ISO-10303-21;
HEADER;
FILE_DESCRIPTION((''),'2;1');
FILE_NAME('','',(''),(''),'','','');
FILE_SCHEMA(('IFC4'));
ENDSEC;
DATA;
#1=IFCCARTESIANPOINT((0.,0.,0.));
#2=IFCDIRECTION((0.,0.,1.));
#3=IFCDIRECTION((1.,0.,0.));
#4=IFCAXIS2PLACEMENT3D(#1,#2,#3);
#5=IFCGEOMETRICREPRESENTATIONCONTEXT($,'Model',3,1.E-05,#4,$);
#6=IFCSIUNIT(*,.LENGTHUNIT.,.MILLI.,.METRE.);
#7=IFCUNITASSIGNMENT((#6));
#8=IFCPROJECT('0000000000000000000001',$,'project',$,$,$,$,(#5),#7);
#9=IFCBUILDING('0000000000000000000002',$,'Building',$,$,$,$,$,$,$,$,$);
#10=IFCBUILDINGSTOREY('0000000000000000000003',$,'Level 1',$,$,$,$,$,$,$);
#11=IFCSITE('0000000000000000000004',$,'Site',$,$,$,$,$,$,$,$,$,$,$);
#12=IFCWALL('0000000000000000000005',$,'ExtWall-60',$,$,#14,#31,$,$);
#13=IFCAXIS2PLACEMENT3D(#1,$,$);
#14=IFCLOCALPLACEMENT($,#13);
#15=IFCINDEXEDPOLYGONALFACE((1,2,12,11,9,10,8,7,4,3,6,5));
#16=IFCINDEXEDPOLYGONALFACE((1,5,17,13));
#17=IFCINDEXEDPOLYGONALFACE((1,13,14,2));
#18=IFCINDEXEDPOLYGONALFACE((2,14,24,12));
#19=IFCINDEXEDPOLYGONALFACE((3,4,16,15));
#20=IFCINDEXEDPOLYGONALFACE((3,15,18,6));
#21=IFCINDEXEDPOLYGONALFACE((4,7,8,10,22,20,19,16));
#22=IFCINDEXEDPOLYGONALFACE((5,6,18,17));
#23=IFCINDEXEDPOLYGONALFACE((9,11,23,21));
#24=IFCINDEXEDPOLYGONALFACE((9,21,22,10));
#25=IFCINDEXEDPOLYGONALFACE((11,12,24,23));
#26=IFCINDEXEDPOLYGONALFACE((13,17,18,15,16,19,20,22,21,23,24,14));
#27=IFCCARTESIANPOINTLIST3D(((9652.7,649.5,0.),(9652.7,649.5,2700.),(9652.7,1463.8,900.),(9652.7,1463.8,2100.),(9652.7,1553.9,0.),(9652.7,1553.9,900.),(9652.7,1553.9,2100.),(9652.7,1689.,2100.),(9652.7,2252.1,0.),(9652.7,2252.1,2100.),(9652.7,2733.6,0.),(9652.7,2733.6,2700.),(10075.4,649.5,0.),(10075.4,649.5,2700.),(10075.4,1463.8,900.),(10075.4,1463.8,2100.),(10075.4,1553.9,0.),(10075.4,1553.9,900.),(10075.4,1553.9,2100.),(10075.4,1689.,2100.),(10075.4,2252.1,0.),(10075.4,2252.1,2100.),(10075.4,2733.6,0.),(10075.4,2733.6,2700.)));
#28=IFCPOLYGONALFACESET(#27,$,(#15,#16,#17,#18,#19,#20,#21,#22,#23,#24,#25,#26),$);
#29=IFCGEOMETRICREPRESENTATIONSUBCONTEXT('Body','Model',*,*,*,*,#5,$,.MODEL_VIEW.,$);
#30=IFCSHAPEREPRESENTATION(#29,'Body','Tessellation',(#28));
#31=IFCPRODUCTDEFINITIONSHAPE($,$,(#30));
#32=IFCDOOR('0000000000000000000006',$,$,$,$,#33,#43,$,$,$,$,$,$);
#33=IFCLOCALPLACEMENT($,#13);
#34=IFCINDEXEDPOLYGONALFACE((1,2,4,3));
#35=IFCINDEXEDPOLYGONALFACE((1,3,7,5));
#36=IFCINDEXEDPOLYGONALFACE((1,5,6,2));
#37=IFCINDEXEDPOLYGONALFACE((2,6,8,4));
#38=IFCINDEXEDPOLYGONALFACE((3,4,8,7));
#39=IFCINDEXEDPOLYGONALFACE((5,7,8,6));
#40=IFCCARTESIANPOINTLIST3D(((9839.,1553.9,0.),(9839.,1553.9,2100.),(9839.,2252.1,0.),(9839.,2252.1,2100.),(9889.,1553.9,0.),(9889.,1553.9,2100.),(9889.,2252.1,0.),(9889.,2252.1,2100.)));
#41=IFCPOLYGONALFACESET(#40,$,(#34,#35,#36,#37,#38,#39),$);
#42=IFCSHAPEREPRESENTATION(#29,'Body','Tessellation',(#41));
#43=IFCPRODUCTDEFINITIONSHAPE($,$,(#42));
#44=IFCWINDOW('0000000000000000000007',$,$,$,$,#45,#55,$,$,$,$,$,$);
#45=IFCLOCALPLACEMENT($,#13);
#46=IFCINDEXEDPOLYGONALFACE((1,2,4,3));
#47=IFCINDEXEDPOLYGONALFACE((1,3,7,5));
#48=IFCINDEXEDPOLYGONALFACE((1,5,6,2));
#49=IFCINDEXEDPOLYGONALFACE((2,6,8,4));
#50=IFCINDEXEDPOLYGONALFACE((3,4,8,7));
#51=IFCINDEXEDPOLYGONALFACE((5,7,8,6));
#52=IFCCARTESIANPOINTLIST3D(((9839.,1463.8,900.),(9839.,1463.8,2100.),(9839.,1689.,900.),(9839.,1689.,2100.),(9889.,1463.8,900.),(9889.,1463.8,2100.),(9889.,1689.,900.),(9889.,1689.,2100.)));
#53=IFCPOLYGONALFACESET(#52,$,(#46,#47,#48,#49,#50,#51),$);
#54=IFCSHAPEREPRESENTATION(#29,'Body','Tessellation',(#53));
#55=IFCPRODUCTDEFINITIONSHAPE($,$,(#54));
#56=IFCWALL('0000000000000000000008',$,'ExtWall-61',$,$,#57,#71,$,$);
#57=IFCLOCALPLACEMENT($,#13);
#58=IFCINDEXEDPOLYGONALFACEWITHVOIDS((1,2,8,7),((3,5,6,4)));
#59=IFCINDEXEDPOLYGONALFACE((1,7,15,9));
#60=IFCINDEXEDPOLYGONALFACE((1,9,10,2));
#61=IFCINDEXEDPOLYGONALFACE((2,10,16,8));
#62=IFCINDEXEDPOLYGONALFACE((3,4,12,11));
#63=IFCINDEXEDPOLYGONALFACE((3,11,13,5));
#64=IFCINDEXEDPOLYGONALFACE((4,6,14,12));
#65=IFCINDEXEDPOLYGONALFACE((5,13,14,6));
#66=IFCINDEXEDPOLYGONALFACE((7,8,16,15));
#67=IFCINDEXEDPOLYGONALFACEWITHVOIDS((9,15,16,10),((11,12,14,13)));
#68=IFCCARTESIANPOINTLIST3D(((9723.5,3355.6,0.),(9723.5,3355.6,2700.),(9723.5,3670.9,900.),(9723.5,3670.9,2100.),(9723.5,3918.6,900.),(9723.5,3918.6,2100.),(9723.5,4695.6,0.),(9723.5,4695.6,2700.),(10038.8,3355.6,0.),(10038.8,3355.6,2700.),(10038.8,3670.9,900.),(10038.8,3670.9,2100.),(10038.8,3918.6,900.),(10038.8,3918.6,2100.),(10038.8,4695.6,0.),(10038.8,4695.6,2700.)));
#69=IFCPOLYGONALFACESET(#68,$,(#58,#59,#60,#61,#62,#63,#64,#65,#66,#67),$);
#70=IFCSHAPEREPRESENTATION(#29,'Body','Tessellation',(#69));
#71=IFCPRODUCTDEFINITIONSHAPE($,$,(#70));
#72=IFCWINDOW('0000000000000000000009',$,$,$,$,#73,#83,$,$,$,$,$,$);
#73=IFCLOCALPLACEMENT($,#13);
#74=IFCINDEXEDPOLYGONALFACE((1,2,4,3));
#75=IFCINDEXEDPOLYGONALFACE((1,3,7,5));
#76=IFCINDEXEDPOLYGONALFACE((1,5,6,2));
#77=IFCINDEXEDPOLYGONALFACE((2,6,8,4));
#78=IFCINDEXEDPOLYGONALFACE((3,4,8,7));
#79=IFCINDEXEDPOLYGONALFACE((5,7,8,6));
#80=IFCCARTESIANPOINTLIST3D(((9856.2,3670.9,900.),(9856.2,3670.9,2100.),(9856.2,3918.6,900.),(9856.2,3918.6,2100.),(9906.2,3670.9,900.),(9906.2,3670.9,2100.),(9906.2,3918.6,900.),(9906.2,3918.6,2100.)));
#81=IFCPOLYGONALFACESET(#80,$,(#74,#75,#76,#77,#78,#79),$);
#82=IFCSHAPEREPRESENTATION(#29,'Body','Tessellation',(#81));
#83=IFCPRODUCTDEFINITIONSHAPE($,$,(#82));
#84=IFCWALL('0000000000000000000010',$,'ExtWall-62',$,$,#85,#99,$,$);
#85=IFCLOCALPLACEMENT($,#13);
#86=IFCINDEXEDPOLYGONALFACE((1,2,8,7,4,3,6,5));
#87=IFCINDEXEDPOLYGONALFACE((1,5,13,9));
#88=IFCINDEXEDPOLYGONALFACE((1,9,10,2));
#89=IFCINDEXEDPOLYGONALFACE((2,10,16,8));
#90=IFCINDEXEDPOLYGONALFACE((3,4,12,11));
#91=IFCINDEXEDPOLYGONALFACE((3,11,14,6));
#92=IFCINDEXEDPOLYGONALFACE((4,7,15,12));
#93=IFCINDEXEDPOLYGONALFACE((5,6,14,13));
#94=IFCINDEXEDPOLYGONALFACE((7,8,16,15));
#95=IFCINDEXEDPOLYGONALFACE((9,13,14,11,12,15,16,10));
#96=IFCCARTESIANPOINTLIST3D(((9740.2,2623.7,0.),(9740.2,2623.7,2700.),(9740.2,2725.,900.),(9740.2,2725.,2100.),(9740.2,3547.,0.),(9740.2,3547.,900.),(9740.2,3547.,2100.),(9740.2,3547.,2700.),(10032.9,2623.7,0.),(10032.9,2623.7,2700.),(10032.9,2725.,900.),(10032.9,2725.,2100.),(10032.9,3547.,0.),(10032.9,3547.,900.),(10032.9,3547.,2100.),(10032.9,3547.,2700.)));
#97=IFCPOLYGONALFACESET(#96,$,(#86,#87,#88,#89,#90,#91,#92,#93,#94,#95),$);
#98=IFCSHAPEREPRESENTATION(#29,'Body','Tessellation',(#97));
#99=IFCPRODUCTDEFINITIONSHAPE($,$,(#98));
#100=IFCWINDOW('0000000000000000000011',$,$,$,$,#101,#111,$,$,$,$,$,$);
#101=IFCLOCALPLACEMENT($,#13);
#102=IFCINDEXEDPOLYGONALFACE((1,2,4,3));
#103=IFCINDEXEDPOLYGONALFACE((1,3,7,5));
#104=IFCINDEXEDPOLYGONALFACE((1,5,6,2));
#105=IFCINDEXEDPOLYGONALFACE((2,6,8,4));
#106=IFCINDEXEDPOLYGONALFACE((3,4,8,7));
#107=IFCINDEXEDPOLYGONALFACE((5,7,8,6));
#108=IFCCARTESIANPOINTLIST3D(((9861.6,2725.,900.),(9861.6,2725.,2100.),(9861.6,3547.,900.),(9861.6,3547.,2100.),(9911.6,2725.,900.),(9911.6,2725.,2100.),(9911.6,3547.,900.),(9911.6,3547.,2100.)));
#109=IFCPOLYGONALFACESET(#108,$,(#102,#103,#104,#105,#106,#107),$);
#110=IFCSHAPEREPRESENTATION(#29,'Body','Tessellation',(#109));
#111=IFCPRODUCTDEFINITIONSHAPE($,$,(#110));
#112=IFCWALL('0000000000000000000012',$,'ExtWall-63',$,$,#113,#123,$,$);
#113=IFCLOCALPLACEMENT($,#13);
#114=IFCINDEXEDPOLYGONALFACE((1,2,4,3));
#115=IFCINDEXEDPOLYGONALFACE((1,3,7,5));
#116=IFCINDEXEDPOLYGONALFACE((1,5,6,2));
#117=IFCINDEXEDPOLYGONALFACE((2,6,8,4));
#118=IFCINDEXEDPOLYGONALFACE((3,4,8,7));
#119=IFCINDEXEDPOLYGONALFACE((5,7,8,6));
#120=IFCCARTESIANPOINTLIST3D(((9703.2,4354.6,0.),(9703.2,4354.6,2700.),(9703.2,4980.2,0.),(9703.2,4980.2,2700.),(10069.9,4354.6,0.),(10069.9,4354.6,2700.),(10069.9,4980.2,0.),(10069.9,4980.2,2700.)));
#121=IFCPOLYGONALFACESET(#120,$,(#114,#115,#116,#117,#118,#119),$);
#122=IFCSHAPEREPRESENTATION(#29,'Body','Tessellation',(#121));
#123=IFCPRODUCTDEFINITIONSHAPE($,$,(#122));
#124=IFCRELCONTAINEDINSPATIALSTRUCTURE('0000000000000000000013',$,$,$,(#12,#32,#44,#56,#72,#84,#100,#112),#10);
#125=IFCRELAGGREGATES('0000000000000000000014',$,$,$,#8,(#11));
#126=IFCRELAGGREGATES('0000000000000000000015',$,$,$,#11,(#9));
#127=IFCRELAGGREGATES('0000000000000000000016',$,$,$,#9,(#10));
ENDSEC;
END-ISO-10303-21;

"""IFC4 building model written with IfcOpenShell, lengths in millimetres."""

from ifc_helpers import new_model, si_unit, frame, origin_with_axes, place, context, subcontext, project, spatial, indexed_curve, outline, extrude, element, fill, save


model = new_model("IFC4")

# Units and contexts
model_context = context("Model", 3, precision=1e-05, world=origin_with_axes())
body_context = subcontext(model_context, "Body", "Model", "MODEL_VIEW")
ifc_project = project(units=[si_unit("LENGTHUNIT", "METRE", prefix="MILLI")], contexts=[model_context])

# Site, building, storey
site = spatial("IfcSite", under=ifc_project, Name="Site")
building = spatial("IfcBuilding", under=site, Name="Building")
storey = spatial("IfcBuildingStorey", under=building, Name="Level 1")

# Wall, openings, door, window
wall_1_placement = place(None, frame((9864.0, 649.5, 0.0), z_axis=(0.0, 0.0, 1.0), x_axis=(0.0, 1.0, 0.0)))
wall_1 = element("IfcWall", 1, at=wall_1_placement, inside=storey, Name="ExtWall-60", context=body_context, shape_type="SweptSolid", body=[
    extrude(outline(indexed_curve([(0.0, 0.0), (0.0, 422.6), (2084.2, 422.6), (2084.2, 0.0), (0.0, 0.0)], self_intersect=False)), frame((0.0, -211.3, 0.0), z_axis=(0.0, 0.0, 1.0), x_axis=(1.0, 0.0, 0.0)), (0.0, 0.0, 1.0), 2700.0),
])
opening_1_placement = place(wall_1_placement, frame((904.5, 0.0, 0.0), z_axis=(0.0, 0.0, 1.0), x_axis=(1.0, 0.0, 0.0)))
opening_1 = element("IfcOpeningElement", 2, at=opening_1_placement, cuts=wall_1, context=body_context, shape_type="SweptSolid", body=[
    extrude(outline(indexed_curve([(0.0, 0.0), (0.0, 522.6), (698.1, 522.6), (698.1, 0.0), (0.0, 0.0)], self_intersect=False)), frame((0.0, -261.3, 0.0), z_axis=(0.0, 0.0, 1.0), x_axis=(1.0, 0.0, 0.0)), (0.0, 0.0, 1.0), 2100.0),
])
opening_2_placement = place(wall_1_placement, frame((814.4, 0.0, 900.0), z_axis=(0.0, 0.0, 1.0), x_axis=(1.0, 0.0, 0.0)))
opening_2 = element("IfcOpeningElement", 3, at=opening_2_placement, cuts=wall_1, context=body_context, shape_type="SweptSolid", body=[
    extrude(outline(indexed_curve([(0.0, 0.0), (0.0, 522.6), (225.2, 522.6), (225.2, 0.0), (0.0, 0.0)], self_intersect=False)), frame((0.0, -261.3, 0.0), z_axis=(0.0, 0.0, 1.0), x_axis=(1.0, 0.0, 0.0)), (0.0, 0.0, 1.0), 1200.0),
])
door_placement = place(opening_1_placement, origin_with_axes())
door = element("IfcDoor", 4, at=door_placement, inside=storey, context=body_context, shape_type="SweptSolid", body=[
    extrude(outline(indexed_curve([(0.0, 0.0), (0.0, 50.0), (698.1, 50.0), (698.1, 0.0), (0.0, 0.0)], self_intersect=False)), frame((0.0, -25.0, 0.0), z_axis=(0.0, 0.0, 1.0), x_axis=(1.0, 0.0, 0.0)), (0.0, 0.0, 1.0), 2100.0),
])
fill(opening_1, door)
window_1_placement = place(opening_2_placement, origin_with_axes())
window_1 = element("IfcWindow", 5, at=window_1_placement, inside=storey, context=body_context, shape_type="SweptSolid", body=[
    extrude(outline(indexed_curve([(0.0, 0.0), (0.0, 50.0), (225.2, 50.0), (225.2, 0.0), (0.0, 0.0)], self_intersect=False)), frame((0.0, -25.0, 0.0), z_axis=(0.0, 0.0, 1.0), x_axis=(1.0, 0.0, 0.0)), (0.0, 0.0, 1.0), 1200.0),
])
fill(opening_2, window_1)

# Walls, openings, windows
wall_2_placement = place(None, frame((9881.2, 3355.6, 0.0), z_axis=(0.0, 0.0, 1.0), x_axis=(0.0, 1.0, 0.0)))
wall_2 = element("IfcWall", 6, at=wall_2_placement, inside=storey, Name="ExtWall-61", context=body_context, shape_type="SweptSolid", body=[
    extrude(outline(indexed_curve([(0.0, 0.0), (0.0, 315.3), (1340.0, 315.3), (1340.0, 0.0), (0.0, 0.0)], self_intersect=False)), frame((0.0, -157.6, 0.0), z_axis=(0.0, 0.0, 1.0), x_axis=(1.0, 0.0, 0.0)), (0.0, 0.0, 1.0), 2700.0),
])
opening_3_placement = place(wall_2_placement, frame((315.3, 0.0, 900.0), z_axis=(0.0, 0.0, 1.0), x_axis=(1.0, 0.0, 0.0)))
opening_3 = element("IfcOpeningElement", 7, at=opening_3_placement, cuts=wall_2, context=body_context, shape_type="SweptSolid", body=[
    extrude(outline(indexed_curve([(0.0, 0.0), (0.0, 415.3), (247.7, 415.3), (247.7, 0.0), (0.0, 0.0)], self_intersect=False)), frame((0.0, -207.6, 0.0), z_axis=(0.0, 0.0, 1.0), x_axis=(1.0, 0.0, 0.0)), (0.0, 0.0, 1.0), 1200.0),
])
window_2_placement = place(opening_3_placement, origin_with_axes())
window_2 = element("IfcWindow", 8, at=window_2_placement, inside=storey, context=body_context, shape_type="SweptSolid", body=[
    extrude(outline(indexed_curve([(0.0, 0.0), (0.0, 50.0), (247.7, 50.0), (247.7, 0.0), (0.0, 0.0)], self_intersect=False)), frame((0.0, -25.0, 0.0), z_axis=(0.0, 0.0, 1.0), x_axis=(1.0, 0.0, 0.0)), (0.0, 0.0, 1.0), 1200.0),
])
fill(opening_3, window_2)
wall_3_placement = place(None, frame((9886.6, 2623.7, 0.0), z_axis=(0.0, 0.0, 1.0), x_axis=(0.0, 1.0, 0.0)))
wall_3 = element("IfcWall", 9, at=wall_3_placement, inside=storey, Name="ExtWall-62", context=body_context, shape_type="SweptSolid", body=[
    extrude(outline(indexed_curve([(0.0, 0.0), (0.0, 292.8), (923.3, 292.8), (923.3, 0.0), (0.0, 0.0)], self_intersect=False)), frame((0.0, -146.4, 0.0), z_axis=(0.0, 0.0, 1.0), x_axis=(1.0, 0.0, 0.0)), (0.0, 0.0, 1.0), 2700.0),
])
opening_4_placement = place(wall_3_placement, frame((101.3, 0.0, 900.0), z_axis=(0.0, 0.0, 1.0), x_axis=(1.0, 0.0, 0.0)))
opening_4 = element("IfcOpeningElement", 10, at=opening_4_placement, cuts=wall_3, context=body_context, shape_type="SweptSolid", body=[
    extrude(outline(indexed_curve([(0.0, 0.0), (0.0, 392.8), (822.0, 392.8), (822.0, 0.0), (0.0, 0.0)], self_intersect=False)), frame((0.0, -196.4, 0.0), z_axis=(0.0, 0.0, 1.0), x_axis=(1.0, 0.0, 0.0)), (0.0, 0.0, 1.0), 1200.0),
])
window_3_placement = place(opening_4_placement, origin_with_axes())
window_3 = element("IfcWindow", 11, at=window_3_placement, inside=storey, context=body_context, shape_type="SweptSolid", body=[
    extrude(outline(indexed_curve([(0.0, 0.0), (0.0, 50.0), (822.0, 50.0), (822.0, 0.0), (0.0, 0.0)], self_intersect=False)), frame((0.0, -25.0, 0.0), z_axis=(0.0, 0.0, 1.0), x_axis=(1.0, 0.0, 0.0)), (0.0, 0.0, 1.0), 1200.0),
])
fill(opening_4, window_3)

# Wall
wall_4_placement = place(None, frame((9886.6, 4354.6, 0.0), z_axis=(0.0, 0.0, 1.0), x_axis=(0.0, 1.0, 0.0)))
element("IfcWall", 12, at=wall_4_placement, inside=storey, Name="ExtWall-63", context=body_context, shape_type="SweptSolid", body=[
    extrude(outline(indexed_curve([(0.0, 0.0), (0.0, 366.6), (625.6, 366.6), (625.6, 0.0), (0.0, 0.0)], self_intersect=False)), frame((0.0, -183.3, 0.0), z_axis=(0.0, 0.0, 1.0), x_axis=(1.0, 0.0, 0.0)), (0.0, 0.0, 1.0), 2700.0),
])

save(model, "model.ifc")
